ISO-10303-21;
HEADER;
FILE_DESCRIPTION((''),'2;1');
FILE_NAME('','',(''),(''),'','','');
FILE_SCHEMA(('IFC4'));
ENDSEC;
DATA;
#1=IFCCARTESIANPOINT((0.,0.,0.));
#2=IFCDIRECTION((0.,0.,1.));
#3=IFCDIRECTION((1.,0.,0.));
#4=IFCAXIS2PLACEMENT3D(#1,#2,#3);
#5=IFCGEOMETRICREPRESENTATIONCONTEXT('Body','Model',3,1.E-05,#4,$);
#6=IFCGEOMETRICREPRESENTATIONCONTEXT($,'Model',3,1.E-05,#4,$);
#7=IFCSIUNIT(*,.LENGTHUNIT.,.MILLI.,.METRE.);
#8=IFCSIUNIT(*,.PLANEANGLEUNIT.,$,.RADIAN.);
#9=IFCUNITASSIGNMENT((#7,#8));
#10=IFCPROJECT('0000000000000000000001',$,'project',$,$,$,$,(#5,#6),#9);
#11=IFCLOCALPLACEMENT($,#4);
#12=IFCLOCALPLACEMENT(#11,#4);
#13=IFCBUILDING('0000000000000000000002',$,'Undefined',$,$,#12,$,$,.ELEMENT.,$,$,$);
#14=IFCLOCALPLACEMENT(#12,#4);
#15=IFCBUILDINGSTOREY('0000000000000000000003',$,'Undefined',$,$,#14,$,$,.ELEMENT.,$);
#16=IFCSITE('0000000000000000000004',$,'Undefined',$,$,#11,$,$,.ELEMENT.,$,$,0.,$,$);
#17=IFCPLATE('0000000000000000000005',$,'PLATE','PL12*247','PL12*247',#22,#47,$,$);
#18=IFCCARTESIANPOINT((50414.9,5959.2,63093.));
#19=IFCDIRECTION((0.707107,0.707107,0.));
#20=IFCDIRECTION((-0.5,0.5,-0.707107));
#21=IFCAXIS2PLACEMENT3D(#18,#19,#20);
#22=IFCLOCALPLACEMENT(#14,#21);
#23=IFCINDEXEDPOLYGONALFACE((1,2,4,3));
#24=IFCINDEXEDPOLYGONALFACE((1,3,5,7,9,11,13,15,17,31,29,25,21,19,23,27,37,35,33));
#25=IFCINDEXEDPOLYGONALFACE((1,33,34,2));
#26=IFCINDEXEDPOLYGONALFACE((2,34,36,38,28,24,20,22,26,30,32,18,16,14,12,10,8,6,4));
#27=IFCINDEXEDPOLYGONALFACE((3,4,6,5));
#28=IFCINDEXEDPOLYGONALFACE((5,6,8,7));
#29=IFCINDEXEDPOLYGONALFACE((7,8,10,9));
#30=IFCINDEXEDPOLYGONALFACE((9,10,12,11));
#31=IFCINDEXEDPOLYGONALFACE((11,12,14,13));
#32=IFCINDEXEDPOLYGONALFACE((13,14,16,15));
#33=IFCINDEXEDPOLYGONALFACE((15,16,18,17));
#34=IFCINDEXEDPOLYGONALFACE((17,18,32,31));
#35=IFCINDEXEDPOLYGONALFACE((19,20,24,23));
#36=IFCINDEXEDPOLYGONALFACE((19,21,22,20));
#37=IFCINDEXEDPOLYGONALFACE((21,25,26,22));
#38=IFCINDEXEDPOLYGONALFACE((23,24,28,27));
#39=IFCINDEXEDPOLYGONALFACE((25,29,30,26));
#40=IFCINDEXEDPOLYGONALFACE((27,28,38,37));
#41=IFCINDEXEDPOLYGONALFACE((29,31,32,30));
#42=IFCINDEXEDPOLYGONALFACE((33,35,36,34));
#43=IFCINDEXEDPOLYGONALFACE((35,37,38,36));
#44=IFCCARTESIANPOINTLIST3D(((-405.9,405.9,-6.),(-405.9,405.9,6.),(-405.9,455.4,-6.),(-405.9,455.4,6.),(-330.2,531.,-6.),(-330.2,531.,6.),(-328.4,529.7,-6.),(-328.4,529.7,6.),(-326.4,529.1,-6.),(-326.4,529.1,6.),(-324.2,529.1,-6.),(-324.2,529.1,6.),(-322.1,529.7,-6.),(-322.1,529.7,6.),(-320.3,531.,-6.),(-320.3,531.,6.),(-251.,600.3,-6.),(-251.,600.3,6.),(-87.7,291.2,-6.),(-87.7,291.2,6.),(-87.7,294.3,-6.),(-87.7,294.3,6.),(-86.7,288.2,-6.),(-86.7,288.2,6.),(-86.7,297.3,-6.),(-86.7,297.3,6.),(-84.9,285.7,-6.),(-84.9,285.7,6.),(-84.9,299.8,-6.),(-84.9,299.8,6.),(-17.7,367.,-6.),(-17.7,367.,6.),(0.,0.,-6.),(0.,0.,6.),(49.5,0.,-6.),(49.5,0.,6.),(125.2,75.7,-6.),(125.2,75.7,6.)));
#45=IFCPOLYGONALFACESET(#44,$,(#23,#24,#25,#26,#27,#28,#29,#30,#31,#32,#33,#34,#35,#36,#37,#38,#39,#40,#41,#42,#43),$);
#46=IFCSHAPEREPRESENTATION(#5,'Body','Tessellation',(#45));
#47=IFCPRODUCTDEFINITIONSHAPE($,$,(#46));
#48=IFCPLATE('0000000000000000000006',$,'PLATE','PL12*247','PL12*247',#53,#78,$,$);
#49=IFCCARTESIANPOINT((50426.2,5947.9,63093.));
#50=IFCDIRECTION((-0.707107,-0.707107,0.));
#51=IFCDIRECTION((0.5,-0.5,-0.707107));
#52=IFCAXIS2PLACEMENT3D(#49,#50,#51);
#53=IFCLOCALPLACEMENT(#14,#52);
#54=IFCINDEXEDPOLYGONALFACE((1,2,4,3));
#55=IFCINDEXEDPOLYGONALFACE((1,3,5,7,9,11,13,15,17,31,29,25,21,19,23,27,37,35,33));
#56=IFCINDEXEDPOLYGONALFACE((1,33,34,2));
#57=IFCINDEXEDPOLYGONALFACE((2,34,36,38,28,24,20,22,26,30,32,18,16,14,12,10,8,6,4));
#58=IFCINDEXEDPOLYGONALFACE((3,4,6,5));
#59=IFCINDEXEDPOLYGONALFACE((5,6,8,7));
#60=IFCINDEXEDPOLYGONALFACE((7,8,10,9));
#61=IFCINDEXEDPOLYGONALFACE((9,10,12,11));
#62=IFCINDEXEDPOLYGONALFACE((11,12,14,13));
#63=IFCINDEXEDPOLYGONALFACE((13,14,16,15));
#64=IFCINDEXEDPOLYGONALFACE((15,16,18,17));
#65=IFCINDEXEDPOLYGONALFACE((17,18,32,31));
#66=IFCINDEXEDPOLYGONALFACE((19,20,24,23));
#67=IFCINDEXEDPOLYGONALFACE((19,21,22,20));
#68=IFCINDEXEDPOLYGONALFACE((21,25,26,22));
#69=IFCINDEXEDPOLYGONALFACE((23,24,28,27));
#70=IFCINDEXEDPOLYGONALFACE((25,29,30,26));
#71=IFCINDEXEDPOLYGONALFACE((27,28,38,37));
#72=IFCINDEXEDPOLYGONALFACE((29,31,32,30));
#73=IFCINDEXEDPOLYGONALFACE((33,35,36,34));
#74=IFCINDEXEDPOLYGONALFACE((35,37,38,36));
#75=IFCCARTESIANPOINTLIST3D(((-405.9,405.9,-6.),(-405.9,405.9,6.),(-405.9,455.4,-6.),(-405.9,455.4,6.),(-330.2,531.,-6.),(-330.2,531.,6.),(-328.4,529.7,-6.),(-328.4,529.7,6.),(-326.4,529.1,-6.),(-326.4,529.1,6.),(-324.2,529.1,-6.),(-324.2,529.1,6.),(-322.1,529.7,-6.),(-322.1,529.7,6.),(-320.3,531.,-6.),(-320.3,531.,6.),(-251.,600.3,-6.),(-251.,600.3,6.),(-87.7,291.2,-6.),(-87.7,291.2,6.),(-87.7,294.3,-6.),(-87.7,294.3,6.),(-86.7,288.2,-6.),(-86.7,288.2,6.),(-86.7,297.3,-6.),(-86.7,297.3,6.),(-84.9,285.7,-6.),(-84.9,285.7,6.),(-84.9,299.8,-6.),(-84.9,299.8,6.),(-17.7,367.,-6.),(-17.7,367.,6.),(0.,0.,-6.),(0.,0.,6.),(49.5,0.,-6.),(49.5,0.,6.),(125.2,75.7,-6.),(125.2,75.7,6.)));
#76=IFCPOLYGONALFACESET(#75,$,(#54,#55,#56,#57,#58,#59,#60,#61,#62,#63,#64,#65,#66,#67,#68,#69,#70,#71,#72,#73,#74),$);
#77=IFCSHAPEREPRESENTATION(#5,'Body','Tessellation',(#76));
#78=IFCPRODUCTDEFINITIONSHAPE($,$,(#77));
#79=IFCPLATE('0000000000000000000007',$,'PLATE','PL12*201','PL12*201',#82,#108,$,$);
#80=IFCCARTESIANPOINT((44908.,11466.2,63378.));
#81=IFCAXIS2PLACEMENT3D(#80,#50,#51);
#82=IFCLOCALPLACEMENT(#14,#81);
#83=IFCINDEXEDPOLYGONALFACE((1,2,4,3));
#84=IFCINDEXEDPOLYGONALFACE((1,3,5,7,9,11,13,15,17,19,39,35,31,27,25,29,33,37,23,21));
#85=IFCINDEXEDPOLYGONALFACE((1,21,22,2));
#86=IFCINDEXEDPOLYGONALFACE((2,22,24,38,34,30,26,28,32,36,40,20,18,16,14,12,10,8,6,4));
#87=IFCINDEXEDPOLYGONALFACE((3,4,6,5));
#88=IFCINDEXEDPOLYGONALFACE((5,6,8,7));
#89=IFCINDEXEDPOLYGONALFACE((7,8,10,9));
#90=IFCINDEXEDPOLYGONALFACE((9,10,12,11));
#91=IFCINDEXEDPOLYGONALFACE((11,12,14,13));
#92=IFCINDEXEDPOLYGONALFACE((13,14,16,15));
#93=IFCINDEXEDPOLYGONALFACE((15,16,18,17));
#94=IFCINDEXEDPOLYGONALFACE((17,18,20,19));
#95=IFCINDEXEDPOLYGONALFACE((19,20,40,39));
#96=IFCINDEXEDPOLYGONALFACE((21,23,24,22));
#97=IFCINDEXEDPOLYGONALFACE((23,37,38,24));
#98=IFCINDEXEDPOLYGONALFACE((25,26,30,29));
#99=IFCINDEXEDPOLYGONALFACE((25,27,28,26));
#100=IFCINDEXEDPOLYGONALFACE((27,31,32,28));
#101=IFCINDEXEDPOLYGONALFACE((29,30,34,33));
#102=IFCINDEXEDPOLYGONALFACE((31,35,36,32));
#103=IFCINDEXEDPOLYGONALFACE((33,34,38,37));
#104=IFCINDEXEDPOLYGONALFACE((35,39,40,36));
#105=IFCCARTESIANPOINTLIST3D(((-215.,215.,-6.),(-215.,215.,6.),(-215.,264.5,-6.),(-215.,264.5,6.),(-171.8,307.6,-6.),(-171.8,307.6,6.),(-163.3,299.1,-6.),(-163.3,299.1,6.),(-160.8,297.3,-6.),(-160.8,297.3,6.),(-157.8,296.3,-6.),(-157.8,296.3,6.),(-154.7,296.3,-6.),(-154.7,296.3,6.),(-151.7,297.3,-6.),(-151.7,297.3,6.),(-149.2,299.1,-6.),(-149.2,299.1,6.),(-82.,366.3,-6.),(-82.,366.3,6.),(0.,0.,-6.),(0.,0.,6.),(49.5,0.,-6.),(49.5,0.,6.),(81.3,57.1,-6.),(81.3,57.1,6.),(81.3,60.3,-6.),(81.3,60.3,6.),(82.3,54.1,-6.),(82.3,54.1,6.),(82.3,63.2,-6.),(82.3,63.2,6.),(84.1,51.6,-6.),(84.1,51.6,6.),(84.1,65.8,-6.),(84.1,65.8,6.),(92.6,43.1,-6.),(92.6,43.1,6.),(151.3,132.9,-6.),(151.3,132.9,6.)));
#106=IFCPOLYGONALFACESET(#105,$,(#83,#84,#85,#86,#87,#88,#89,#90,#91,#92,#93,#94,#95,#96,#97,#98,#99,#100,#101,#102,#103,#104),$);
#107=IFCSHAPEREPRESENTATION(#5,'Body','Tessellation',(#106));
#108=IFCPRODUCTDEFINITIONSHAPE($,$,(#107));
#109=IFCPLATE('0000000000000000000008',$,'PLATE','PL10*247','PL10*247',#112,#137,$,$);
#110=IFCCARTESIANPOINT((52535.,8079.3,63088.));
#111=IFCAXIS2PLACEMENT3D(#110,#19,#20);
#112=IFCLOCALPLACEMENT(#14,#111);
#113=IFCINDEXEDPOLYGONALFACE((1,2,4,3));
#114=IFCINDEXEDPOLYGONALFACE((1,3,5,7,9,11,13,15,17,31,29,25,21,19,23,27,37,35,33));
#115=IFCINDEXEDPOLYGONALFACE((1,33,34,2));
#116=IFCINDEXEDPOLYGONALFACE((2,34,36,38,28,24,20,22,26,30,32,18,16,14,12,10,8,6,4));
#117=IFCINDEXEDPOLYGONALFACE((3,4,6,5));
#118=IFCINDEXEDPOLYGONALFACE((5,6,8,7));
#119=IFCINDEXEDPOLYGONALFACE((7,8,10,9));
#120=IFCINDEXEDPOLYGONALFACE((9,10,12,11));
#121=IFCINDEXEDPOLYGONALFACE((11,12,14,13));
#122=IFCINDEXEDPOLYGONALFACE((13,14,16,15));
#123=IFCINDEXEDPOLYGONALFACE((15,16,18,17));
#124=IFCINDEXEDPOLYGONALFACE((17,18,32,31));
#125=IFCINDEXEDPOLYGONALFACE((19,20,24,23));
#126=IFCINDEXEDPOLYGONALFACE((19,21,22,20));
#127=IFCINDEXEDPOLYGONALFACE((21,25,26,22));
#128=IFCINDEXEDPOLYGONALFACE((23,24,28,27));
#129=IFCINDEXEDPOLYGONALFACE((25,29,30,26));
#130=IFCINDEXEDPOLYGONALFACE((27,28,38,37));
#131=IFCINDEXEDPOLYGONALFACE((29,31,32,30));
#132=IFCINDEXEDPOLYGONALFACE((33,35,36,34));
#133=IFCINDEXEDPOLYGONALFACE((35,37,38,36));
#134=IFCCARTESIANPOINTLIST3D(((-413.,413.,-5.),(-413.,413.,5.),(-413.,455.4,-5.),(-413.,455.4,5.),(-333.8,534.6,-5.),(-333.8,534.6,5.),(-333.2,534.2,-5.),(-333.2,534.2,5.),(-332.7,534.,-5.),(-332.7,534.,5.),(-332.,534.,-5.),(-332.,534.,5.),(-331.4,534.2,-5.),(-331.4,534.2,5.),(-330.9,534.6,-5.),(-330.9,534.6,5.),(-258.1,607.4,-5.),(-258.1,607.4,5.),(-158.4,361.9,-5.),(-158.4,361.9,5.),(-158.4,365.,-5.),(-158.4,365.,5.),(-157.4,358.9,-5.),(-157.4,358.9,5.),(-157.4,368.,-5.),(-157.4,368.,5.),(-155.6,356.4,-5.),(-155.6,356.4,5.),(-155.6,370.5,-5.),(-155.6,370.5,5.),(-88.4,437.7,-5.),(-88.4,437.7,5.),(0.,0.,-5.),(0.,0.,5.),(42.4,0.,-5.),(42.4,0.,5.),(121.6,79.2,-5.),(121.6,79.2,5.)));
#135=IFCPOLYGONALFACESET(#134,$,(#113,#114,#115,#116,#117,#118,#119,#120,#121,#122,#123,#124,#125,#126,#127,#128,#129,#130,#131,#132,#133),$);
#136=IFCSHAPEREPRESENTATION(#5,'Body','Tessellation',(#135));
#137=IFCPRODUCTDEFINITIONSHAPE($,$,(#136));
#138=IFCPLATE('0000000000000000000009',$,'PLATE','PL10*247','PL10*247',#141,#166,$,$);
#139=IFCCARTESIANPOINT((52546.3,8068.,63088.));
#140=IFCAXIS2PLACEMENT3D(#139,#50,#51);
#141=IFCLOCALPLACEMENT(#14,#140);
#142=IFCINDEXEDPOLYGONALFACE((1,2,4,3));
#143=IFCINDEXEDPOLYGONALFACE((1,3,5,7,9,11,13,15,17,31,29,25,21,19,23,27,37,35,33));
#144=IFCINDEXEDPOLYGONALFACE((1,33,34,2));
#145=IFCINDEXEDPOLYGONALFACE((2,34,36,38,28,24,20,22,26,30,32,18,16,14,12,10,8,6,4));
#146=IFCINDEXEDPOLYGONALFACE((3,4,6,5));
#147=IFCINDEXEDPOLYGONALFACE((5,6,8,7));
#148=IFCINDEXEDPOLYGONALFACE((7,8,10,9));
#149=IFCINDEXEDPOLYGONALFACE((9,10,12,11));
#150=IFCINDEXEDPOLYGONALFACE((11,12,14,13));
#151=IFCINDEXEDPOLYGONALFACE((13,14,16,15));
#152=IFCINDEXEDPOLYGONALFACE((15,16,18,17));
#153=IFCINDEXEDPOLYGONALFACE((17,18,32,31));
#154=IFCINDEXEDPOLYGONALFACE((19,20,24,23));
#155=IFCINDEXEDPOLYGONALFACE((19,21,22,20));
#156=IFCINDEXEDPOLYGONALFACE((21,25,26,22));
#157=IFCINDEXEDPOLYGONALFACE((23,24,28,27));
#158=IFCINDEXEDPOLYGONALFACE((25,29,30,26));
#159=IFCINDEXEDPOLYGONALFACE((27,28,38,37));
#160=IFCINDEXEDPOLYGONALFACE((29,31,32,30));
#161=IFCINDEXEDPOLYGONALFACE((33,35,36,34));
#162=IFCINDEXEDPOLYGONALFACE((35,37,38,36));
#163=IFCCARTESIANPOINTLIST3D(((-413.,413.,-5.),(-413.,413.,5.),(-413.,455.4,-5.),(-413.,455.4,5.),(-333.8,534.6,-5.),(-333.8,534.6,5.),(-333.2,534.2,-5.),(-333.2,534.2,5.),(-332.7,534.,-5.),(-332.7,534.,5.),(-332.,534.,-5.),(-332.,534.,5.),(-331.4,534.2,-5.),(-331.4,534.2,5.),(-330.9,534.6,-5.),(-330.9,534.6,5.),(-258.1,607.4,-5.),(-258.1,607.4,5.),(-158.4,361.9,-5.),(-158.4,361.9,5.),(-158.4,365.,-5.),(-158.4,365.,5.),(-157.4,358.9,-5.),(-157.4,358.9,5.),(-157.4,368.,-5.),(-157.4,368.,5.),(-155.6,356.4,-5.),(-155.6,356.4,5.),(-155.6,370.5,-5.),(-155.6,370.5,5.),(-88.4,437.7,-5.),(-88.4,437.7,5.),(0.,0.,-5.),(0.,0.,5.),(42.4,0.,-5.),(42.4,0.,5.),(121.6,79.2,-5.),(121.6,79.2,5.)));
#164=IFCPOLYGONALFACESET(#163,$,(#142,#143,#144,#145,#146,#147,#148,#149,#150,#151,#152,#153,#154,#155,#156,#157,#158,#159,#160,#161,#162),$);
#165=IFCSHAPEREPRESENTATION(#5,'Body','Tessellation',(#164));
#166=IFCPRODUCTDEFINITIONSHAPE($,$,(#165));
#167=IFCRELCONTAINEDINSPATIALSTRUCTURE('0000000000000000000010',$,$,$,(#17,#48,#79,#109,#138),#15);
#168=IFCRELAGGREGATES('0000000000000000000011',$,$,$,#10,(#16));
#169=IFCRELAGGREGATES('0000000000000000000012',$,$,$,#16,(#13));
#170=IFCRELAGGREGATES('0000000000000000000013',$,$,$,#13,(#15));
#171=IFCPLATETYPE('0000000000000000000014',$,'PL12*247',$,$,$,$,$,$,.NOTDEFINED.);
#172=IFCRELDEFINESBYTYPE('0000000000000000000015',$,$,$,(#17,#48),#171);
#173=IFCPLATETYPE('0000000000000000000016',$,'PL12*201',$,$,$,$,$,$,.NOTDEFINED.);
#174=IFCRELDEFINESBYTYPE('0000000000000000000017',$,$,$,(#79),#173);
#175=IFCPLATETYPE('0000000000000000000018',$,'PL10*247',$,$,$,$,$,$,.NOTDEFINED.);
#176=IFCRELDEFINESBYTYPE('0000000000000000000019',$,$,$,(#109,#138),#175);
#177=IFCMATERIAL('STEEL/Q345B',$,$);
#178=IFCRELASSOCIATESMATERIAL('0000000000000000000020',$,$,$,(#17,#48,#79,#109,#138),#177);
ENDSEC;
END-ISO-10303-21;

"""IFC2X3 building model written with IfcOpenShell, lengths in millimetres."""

from ifc_helpers import new_model, si_unit, frame, origin_with_axes, place, context, project, spatial, polyline, outline, extrude, material, type_object, element, save


model = new_model("IFC2X3")

# Units and contexts
model_context_1 = context("Model", 3, precision=1e-05, world=origin_with_axes(), identifier="Body")
model_context_2 = context("Model", 3, precision=1e-05, world=origin_with_axes())
ifc_project = project(units=[si_unit("LENGTHUNIT", "METRE", prefix="MILLI"), si_unit("PLANEANGLEUNIT", "RADIAN")], contexts=[model_context_1, model_context_2])

# Site, building, storey
site_placement = place(None, origin_with_axes())
site = spatial("IfcSite", under=ifc_project, at=site_placement, Name="Undefined", CompositionType="ELEMENT", RefElevation=0.0)
building_placement = place(site_placement, origin_with_axes())
building = spatial("IfcBuilding", under=site, at=building_placement, Name="Undefined", CompositionType="ELEMENT")
storey_placement = place(building_placement, origin_with_axes())
storey = spatial("IfcBuildingStorey", under=building, at=storey_placement, Name="Undefined", CompositionType="ELEMENT")

# Shared definitions
ifc_material_1 = material(Name="STEEL/Q345B")

# Plates
plate_type_1 = type_object("IfcPlateType", Name="PL12*247", PredefinedType="NOTDEFINED")
plate_1_placement = place(storey_placement, frame((50414.9, 5959.2, 63093.0), z_axis=(0.707107, 0.707107, 0.0), x_axis=(-0.5, 0.5, -0.707107)))
element("IfcPlate", 1, at=plate_1_placement, inside=storey, type_object=plate_type_1, material=ifc_material_1, Name="PLATE", Description="PL12*247", ObjectType="PL12*247", context=model_context_1, shape_type="SweptSolid", body=[
    extrude(outline(polyline([(0.0, 0.0), (49.5, 0.0), (125.2, 75.7), (-84.9, 285.7), (-86.7, 288.2), (-87.7, 291.2), (-87.7, 294.3), (-86.7, 297.3), (-84.9, 299.8), (-17.7, 367.0), (-251.0, 600.3), (-320.3, 531.0), (-322.1, 529.7), (-324.2, 529.1), (-326.4, 529.1), (-328.4, 529.7), (-330.2, 531.0), (-405.9, 455.4), (-405.9, 405.9), (0.0, 0.0)])), frame((0.0, 0.0, -6.0), z_axis=(0.0, 0.0, 1.0), x_axis=(1.0, 0.0, 0.0)), (0.0, 0.0, 1.0), 12.0),
])
plate_2_placement = place(storey_placement, frame((50426.2, 5947.9, 63093.0), z_axis=(-0.707107, -0.707107, 0.0), x_axis=(0.5, -0.5, -0.707107)))
element("IfcPlate", 2, at=plate_2_placement, inside=storey, type_object=plate_type_1, material=ifc_material_1, Name="PLATE", Description="PL12*247", ObjectType="PL12*247", context=model_context_1, shape_type="SweptSolid", body=[
    extrude(outline(polyline([(0.0, 0.0), (49.5, 0.0), (125.2, 75.7), (-84.9, 285.7), (-86.7, 288.2), (-87.7, 291.2), (-87.7, 294.3), (-86.7, 297.3), (-84.9, 299.8), (-17.7, 367.0), (-251.0, 600.3), (-320.3, 531.0), (-322.1, 529.7), (-324.2, 529.1), (-326.4, 529.1), (-328.4, 529.7), (-330.2, 531.0), (-405.9, 455.4), (-405.9, 405.9), (0.0, 0.0)])), frame((0.0, 0.0, -6.0), z_axis=(0.0, 0.0, 1.0), x_axis=(1.0, 0.0, 0.0)), (0.0, 0.0, 1.0), 12.0),
])
plate_type_2 = type_object("IfcPlateType", Name="PL12*201", PredefinedType="NOTDEFINED")
plate_3_placement = place(storey_placement, frame((44908.0, 11466.2, 63378.0), z_axis=(-0.707107, -0.707107, 0.0), x_axis=(0.5, -0.5, -0.707107)))
element("IfcPlate", 3, at=plate_3_placement, inside=storey, type_object=plate_type_2, material=ifc_material_1, Name="PLATE", Description="PL12*201", ObjectType="PL12*201", context=model_context_1, shape_type="SweptSolid", body=[
    extrude(outline(polyline([(0.0, 0.0), (49.5, 0.0), (92.6, 43.1), (84.1, 51.6), (82.3, 54.1), (81.3, 57.1), (81.3, 60.3), (82.3, 63.2), (84.1, 65.8), (151.3, 132.9), (-82.0, 366.3), (-149.2, 299.1), (-151.7, 297.3), (-154.7, 296.3), (-157.8, 296.3), (-160.8, 297.3), (-163.3, 299.1), (-171.8, 307.6), (-215.0, 264.5), (-215.0, 215.0), (0.0, 0.0)])), frame((0.0, 0.0, -6.0), z_axis=(0.0, 0.0, 1.0), x_axis=(1.0, 0.0, 0.0)), (0.0, 0.0, 1.0), 12.0),
])
plate_type_3 = type_object("IfcPlateType", Name="PL10*247", PredefinedType="NOTDEFINED")
plate_4_placement = place(storey_placement, frame((52535.0, 8079.3, 63088.0), z_axis=(0.707107, 0.707107, 0.0), x_axis=(-0.5, 0.5, -0.707107)))
element("IfcPlate", 4, at=plate_4_placement, inside=storey, type_object=plate_type_3, material=ifc_material_1, Name="PLATE", Description="PL10*247", ObjectType="PL10*247", context=model_context_1, shape_type="SweptSolid", body=[
    extrude(outline(polyline([(0.0, 0.0), (42.4, 0.0), (121.6, 79.2), (-155.6, 356.4), (-157.4, 358.9), (-158.4, 361.9), (-158.4, 365.0), (-157.4, 368.0), (-155.6, 370.5), (-88.4, 437.7), (-258.1, 607.4), (-330.9, 534.6), (-331.4, 534.2), (-332.0, 534.0), (-332.7, 534.0), (-333.2, 534.2), (-333.8, 534.6), (-413.0, 455.4), (-413.0, 413.0), (0.0, 0.0)])), frame((0.0, 0.0, -5.0), z_axis=(0.0, 0.0, 1.0), x_axis=(1.0, 0.0, 0.0)), (0.0, 0.0, 1.0), 10.0),
])
plate_5_placement = place(storey_placement, frame((52546.3, 8068.0, 63088.0), z_axis=(-0.707107, -0.707107, 0.0), x_axis=(0.5, -0.5, -0.707107)))
element("IfcPlate", 5, at=plate_5_placement, inside=storey, type_object=plate_type_3, material=ifc_material_1, Name="PLATE", Description="PL10*247", ObjectType="PL10*247", context=model_context_1, shape_type="SweptSolid", body=[
    extrude(outline(polyline([(0.0, 0.0), (42.4, 0.0), (121.6, 79.2), (-155.6, 356.4), (-157.4, 358.9), (-158.4, 361.9), (-158.4, 365.0), (-157.4, 368.0), (-155.6, 370.5), (-88.4, 437.7), (-258.1, 607.4), (-330.9, 534.6), (-331.4, 534.2), (-332.0, 534.0), (-332.7, 534.0), (-333.2, 534.2), (-333.8, 534.6), (-413.0, 455.4), (-413.0, 413.0), (0.0, 0.0)])), frame((0.0, 0.0, -5.0), z_axis=(0.0, 0.0, 1.0), x_axis=(1.0, 0.0, 0.0)), (0.0, 0.0, 1.0), 10.0),
])

save(model, "model.ifc")
